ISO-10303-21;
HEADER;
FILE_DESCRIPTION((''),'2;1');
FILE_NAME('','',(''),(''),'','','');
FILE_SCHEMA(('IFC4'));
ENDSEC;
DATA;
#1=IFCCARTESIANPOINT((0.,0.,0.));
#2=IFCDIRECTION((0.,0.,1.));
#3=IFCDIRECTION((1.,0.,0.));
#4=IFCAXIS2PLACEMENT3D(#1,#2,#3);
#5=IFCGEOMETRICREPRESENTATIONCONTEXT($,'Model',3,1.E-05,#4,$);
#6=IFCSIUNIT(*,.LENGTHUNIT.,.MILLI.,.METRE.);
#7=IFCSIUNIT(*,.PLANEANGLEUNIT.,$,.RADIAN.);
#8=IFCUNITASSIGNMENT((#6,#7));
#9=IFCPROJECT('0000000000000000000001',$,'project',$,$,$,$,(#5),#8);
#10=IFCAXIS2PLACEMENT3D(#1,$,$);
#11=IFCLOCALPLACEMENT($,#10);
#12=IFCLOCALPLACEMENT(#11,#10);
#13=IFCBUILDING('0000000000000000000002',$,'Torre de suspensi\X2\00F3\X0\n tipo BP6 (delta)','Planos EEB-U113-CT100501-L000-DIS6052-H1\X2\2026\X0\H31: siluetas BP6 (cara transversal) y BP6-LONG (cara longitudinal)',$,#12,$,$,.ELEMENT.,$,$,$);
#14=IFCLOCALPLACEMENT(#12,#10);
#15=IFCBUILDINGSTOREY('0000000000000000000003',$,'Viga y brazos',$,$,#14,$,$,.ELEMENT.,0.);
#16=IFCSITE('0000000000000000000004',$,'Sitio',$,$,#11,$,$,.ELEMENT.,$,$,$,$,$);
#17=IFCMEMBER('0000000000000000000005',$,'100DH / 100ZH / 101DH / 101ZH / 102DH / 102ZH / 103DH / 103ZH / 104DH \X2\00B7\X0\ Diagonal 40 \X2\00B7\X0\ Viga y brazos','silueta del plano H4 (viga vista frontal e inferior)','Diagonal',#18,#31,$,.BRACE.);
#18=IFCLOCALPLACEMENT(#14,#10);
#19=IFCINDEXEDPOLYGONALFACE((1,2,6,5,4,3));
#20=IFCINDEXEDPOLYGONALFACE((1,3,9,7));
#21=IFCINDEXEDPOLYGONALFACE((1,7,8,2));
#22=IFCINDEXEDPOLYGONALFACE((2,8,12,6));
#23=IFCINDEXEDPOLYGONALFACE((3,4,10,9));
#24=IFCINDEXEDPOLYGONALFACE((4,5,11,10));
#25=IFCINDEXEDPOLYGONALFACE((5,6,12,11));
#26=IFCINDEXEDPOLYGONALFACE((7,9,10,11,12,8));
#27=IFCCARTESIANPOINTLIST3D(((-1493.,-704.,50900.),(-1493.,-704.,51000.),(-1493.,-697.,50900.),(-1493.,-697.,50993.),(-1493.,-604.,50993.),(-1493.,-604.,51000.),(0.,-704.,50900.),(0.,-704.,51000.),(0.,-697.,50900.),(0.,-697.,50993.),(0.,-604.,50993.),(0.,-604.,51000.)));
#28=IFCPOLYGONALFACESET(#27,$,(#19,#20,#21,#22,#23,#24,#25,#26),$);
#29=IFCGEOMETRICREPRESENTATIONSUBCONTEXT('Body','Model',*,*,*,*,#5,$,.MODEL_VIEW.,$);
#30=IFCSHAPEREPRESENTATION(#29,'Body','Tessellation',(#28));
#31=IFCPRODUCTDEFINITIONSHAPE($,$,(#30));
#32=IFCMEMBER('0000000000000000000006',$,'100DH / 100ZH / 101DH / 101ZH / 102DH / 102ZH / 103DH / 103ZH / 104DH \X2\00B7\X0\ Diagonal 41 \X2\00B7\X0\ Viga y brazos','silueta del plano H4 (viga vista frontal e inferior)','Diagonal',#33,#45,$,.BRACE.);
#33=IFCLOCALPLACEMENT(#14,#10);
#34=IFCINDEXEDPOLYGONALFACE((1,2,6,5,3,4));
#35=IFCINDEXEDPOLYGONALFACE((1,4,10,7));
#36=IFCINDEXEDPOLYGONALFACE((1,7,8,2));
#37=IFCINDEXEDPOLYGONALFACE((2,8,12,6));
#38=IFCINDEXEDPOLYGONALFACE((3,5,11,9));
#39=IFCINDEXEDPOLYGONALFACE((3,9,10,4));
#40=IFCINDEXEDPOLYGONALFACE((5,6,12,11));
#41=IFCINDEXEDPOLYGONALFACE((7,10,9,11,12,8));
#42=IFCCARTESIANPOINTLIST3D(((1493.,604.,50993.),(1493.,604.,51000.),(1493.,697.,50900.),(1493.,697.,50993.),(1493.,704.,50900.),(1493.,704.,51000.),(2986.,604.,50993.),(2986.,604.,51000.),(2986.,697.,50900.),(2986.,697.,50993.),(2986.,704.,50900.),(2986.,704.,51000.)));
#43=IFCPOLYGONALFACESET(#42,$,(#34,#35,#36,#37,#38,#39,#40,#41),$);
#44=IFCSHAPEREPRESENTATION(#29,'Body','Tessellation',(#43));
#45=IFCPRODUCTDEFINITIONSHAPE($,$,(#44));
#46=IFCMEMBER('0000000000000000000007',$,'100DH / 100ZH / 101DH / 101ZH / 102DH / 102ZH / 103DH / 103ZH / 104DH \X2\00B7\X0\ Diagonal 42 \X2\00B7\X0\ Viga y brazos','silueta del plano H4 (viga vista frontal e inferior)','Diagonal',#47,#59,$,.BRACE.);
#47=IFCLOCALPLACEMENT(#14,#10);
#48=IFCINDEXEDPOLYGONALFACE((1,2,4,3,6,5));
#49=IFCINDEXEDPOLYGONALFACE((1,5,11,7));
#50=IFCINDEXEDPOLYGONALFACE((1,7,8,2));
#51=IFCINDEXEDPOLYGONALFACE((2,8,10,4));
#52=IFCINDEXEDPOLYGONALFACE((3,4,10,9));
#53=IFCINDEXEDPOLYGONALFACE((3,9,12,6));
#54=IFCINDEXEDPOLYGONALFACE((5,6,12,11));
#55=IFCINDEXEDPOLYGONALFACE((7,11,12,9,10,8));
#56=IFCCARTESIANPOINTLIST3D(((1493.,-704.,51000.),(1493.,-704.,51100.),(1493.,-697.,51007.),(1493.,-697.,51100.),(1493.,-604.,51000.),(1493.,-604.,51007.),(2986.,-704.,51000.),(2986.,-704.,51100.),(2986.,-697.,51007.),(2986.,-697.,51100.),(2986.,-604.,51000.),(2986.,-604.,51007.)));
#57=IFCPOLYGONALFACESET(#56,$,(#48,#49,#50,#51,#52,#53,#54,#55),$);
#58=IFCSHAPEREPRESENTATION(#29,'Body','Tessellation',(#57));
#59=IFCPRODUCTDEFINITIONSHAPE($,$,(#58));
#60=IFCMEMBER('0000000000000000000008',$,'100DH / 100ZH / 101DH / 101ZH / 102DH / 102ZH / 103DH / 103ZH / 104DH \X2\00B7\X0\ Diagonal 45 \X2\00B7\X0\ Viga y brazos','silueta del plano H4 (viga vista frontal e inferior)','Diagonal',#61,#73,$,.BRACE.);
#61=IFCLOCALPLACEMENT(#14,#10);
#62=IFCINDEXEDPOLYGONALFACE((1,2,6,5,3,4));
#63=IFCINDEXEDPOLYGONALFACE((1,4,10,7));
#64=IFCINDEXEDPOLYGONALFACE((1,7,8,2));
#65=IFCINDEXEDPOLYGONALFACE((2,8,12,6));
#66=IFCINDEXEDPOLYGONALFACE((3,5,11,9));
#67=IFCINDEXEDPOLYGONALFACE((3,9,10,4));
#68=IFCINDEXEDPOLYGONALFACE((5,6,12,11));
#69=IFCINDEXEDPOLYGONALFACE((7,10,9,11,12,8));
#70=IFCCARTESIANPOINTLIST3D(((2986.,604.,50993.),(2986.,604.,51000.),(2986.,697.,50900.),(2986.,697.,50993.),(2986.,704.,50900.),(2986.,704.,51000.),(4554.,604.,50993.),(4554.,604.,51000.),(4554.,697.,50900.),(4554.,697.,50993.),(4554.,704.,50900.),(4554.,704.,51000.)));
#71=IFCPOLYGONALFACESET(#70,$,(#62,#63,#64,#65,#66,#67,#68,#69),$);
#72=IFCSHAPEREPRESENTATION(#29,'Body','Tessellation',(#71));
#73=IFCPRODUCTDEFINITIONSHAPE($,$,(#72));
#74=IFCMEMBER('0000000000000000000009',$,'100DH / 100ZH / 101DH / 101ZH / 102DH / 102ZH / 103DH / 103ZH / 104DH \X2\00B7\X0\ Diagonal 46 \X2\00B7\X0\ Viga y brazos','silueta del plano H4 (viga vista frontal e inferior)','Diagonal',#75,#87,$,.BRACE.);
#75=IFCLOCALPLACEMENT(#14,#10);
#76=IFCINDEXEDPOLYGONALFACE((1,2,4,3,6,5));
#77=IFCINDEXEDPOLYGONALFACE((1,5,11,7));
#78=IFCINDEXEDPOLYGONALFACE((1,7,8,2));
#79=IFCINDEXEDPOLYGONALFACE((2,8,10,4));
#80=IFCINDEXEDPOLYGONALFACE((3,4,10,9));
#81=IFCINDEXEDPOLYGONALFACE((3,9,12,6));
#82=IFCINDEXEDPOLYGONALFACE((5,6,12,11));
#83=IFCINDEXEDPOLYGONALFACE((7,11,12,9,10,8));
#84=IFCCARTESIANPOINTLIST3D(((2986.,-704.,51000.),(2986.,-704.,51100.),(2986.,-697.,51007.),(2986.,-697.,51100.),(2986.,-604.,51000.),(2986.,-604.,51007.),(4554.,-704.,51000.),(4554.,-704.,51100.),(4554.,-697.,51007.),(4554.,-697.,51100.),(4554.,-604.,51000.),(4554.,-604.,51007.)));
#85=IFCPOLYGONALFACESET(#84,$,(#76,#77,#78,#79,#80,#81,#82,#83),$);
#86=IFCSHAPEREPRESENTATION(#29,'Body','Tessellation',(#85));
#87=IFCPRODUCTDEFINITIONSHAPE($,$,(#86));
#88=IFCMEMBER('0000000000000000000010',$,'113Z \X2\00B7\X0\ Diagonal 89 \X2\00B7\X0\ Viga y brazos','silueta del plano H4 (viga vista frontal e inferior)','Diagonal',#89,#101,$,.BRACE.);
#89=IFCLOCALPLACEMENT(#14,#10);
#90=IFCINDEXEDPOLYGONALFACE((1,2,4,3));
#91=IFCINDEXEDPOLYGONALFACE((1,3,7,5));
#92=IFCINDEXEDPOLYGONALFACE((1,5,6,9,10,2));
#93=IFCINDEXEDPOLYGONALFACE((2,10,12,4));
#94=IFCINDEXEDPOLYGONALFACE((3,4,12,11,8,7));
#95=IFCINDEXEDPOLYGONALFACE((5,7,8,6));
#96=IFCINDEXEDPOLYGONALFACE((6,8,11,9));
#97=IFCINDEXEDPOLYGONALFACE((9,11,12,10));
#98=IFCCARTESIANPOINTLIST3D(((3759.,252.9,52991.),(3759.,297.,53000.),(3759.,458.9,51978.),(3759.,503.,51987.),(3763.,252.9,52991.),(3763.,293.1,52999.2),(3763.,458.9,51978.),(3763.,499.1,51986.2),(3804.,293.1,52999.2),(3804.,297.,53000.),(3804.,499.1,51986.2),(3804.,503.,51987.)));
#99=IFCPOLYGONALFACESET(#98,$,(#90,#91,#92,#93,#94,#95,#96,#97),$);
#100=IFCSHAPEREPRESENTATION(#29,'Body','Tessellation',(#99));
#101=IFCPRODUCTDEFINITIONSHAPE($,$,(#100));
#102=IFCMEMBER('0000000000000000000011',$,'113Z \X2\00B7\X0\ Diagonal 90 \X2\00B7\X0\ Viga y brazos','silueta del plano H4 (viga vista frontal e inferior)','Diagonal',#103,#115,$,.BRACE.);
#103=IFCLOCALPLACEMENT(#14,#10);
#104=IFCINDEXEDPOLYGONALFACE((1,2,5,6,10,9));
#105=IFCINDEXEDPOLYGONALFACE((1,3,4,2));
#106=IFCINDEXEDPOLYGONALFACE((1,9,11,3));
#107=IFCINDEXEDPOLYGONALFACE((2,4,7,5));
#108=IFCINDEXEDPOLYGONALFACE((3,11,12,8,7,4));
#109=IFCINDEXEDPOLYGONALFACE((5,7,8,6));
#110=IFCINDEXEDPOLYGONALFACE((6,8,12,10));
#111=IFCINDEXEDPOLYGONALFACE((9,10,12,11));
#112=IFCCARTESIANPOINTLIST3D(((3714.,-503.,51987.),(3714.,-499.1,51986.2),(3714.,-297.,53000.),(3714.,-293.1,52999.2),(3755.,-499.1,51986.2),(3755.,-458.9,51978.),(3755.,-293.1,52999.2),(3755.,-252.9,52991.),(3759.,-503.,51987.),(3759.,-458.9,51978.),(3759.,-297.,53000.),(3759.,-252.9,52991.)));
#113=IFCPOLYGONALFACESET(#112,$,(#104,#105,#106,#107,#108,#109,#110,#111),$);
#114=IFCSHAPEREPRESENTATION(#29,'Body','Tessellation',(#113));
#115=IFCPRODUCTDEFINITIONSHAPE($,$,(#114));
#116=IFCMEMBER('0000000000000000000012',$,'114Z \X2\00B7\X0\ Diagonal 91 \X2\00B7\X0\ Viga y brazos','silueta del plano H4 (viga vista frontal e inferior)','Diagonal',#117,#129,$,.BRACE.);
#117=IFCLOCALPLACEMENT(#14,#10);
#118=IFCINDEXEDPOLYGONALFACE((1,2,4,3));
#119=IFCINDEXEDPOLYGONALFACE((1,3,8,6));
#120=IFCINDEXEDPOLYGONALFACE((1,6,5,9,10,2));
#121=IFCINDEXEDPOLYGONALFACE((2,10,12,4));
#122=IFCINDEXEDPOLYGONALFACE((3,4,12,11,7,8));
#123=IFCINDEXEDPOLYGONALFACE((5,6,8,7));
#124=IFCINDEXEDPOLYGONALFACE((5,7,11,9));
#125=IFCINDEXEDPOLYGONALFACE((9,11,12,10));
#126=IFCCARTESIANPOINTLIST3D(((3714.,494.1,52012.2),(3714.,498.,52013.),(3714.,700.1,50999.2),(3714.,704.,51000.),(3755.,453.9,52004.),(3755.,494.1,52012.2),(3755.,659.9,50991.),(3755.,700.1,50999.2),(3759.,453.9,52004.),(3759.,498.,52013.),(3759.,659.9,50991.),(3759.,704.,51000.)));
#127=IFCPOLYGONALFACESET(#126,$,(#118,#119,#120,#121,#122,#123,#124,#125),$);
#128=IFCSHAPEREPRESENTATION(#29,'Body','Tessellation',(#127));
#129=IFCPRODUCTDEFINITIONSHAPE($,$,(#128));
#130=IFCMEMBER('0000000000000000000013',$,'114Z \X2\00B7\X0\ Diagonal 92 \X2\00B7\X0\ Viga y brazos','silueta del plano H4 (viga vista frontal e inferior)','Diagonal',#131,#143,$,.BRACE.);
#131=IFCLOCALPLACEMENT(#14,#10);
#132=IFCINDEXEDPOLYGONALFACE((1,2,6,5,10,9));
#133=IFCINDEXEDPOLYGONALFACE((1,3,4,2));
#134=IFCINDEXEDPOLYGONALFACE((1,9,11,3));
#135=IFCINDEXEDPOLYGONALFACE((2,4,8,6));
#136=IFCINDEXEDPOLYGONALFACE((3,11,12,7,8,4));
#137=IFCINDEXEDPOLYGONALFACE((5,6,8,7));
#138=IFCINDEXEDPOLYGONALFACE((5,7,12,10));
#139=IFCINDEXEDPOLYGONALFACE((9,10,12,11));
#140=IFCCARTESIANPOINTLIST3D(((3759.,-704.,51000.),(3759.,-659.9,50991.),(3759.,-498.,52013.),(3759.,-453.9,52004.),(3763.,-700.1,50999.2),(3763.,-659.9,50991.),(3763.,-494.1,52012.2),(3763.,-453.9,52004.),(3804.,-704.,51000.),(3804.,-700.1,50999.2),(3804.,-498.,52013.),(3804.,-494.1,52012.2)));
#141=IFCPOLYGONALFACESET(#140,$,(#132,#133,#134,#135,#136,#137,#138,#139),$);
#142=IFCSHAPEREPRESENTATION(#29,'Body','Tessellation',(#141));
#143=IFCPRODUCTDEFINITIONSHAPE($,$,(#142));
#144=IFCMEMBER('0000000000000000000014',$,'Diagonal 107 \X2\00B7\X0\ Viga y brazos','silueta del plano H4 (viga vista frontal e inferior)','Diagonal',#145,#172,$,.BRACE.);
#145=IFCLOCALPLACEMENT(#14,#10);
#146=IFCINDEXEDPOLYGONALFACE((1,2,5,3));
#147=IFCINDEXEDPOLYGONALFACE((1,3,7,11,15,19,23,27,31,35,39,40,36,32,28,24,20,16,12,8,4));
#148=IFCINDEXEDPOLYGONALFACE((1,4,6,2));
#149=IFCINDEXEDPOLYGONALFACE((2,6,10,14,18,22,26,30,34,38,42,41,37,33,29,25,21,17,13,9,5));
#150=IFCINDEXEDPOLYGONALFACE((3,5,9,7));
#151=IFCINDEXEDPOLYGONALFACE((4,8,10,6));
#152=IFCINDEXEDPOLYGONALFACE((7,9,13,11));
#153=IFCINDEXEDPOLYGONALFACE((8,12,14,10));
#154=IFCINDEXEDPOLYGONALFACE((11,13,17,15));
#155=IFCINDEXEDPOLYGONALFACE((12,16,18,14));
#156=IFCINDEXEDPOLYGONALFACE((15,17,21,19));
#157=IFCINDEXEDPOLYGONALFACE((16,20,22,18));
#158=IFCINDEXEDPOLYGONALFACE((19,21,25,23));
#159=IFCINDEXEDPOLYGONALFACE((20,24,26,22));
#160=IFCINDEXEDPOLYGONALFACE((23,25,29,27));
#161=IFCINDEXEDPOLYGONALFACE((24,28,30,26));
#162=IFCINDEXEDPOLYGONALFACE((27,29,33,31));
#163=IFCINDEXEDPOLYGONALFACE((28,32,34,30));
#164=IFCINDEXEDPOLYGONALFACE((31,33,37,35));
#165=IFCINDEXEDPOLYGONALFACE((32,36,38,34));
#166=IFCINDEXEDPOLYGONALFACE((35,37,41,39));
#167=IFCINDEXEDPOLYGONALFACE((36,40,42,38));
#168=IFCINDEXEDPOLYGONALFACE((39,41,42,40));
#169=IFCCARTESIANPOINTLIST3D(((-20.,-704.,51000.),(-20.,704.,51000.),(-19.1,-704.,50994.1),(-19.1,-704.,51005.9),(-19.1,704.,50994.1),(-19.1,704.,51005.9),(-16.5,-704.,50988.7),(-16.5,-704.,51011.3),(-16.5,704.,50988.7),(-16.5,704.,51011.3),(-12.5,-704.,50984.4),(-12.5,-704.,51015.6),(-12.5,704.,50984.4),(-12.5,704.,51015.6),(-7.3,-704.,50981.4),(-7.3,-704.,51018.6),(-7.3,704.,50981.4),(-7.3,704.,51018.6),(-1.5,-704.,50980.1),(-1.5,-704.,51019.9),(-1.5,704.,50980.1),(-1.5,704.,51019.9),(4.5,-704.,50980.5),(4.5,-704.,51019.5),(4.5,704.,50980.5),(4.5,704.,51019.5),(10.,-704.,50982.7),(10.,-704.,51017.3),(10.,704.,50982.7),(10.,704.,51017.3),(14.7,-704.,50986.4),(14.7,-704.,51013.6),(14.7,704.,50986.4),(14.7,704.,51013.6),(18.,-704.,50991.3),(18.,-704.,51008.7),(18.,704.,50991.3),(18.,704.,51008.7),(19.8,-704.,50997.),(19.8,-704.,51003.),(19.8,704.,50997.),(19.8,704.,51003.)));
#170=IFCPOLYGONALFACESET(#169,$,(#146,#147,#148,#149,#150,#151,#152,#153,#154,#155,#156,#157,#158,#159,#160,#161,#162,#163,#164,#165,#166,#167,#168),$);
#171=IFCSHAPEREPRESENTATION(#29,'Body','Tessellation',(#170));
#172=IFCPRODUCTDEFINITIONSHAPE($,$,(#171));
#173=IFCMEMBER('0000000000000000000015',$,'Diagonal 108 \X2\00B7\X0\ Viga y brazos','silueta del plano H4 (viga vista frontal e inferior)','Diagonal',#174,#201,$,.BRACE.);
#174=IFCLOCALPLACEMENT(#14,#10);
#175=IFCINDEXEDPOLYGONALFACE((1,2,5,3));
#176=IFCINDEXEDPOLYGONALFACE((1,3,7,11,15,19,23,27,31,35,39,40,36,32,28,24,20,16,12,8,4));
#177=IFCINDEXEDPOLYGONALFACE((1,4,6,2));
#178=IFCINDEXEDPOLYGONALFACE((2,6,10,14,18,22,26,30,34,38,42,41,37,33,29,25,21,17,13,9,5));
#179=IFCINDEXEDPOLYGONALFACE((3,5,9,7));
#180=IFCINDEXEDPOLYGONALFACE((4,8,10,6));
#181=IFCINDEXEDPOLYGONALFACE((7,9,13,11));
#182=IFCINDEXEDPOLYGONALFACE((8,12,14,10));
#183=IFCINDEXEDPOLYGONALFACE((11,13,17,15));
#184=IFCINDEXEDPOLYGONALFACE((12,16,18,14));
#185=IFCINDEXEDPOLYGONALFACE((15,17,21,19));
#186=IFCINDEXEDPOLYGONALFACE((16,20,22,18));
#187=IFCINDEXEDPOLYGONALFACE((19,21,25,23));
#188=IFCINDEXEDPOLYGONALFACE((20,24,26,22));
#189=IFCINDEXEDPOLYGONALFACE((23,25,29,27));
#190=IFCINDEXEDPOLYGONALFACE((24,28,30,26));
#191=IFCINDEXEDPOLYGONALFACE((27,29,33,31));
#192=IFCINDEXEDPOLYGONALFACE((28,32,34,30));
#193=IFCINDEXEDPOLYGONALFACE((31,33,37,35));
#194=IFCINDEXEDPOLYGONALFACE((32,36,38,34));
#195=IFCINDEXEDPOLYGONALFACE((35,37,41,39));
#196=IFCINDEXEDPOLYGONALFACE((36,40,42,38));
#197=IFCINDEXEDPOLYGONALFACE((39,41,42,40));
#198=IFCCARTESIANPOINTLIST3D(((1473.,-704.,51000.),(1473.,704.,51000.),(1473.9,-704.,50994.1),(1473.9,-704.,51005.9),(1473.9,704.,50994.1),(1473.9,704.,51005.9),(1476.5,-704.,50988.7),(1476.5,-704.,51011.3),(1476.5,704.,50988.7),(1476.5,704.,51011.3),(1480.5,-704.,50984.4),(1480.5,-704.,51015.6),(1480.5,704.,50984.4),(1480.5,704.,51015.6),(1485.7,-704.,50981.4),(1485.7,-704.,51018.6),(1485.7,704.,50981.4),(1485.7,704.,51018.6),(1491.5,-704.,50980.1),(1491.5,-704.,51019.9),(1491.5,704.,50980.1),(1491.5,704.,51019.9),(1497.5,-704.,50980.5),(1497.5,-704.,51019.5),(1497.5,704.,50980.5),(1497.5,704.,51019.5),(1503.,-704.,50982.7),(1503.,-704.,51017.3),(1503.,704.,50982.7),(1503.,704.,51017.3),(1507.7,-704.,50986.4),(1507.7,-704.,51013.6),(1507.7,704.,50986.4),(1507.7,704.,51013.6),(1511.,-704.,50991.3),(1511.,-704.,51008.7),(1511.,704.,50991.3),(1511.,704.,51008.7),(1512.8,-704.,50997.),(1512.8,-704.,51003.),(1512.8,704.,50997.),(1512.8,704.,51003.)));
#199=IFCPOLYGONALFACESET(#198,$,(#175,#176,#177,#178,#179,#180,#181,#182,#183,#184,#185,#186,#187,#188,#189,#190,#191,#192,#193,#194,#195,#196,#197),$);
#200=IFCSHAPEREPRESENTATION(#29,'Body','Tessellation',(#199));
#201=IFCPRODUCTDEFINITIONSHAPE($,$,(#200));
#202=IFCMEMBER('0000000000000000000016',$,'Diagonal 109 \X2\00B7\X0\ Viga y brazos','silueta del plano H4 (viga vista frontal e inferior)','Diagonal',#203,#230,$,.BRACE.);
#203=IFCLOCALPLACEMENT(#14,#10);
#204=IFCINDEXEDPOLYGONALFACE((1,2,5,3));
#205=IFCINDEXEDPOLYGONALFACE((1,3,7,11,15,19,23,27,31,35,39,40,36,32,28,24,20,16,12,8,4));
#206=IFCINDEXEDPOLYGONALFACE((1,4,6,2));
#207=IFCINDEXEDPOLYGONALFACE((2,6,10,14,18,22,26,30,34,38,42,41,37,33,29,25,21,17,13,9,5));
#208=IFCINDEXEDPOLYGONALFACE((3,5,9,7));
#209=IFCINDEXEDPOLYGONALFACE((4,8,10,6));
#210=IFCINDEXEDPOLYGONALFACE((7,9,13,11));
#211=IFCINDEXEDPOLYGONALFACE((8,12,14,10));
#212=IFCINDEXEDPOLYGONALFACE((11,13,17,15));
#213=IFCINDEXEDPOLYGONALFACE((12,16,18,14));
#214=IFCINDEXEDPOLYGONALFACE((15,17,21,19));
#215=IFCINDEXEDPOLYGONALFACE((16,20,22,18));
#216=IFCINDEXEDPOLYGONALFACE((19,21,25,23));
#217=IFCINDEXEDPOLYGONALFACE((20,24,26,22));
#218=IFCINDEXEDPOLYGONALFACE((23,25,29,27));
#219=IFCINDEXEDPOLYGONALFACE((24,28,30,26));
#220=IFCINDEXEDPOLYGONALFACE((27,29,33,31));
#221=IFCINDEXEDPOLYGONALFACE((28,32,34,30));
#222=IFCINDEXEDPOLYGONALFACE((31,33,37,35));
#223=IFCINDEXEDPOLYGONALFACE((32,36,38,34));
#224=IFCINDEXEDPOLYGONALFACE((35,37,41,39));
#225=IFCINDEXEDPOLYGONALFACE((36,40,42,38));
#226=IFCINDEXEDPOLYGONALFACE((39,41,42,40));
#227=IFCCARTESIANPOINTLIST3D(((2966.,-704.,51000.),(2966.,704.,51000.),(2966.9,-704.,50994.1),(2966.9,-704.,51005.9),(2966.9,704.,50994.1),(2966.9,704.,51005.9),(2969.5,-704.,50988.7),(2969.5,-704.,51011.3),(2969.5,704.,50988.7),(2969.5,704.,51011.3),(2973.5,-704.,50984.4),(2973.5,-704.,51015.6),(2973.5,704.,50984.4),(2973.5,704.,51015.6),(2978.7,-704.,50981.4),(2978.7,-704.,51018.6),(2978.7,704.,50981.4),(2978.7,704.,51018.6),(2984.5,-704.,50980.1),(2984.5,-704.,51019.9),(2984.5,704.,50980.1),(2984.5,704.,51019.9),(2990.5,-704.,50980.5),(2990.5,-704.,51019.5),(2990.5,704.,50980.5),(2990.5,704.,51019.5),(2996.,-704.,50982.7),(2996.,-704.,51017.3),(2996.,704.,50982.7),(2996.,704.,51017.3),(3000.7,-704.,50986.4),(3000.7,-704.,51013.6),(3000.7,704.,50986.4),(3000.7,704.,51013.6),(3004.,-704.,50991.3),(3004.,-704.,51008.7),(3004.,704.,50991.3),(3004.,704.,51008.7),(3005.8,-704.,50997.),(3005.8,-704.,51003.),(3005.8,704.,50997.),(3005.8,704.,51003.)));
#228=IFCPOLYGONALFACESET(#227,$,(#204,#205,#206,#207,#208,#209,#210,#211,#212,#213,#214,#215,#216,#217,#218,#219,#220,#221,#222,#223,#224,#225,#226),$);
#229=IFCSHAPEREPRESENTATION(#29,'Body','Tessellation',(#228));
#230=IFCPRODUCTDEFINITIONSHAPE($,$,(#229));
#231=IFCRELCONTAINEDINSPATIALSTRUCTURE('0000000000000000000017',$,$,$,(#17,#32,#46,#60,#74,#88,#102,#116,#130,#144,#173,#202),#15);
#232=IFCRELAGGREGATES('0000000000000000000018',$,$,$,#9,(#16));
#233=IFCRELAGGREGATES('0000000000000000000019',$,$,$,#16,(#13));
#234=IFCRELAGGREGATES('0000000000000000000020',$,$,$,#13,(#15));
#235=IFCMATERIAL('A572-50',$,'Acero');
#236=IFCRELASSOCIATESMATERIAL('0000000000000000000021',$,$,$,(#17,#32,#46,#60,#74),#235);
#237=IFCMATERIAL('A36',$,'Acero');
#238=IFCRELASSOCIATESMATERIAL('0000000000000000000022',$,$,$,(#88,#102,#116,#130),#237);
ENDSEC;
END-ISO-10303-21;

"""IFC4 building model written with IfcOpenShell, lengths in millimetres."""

from ifc_helpers import new_model, si_unit, frame, frame_2d, origin, origin_with_axes, place, context, subcontext, project, spatial, circle, l_section, extrude, material, element, save


model = new_model("IFC4")

# Units and contexts
model_context = context("Model", 3, precision=1e-05, world=origin_with_axes())
body_context = subcontext(model_context, "Body", "Model", "MODEL_VIEW")
ifc_project = project(units=[si_unit("LENGTHUNIT", "METRE", prefix="MILLI"), si_unit("PLANEANGLEUNIT", "RADIAN")], contexts=[model_context])

# Site, building, storey
site_placement = place(None, origin())
site = spatial("IfcSite", under=ifc_project, at=site_placement, Name="Sitio", CompositionType="ELEMENT")
building_placement = place(site_placement, origin())
building = spatial("IfcBuilding", under=site, at=building_placement, Name="Torre de suspensión tipo BP6 (delta)", Description="Planos EEB-U113-CT100501-L000-DIS6052-H1…H31: siluetas BP6 (cara transversal) y BP6-LONG (cara longitudinal)", CompositionType="ELEMENT")
storey_placement = place(building_placement, origin())
storey = spatial("IfcBuildingStorey", under=building, at=storey_placement, Name="Viga y brazos", CompositionType="ELEMENT", Elevation=0.0)

# Members
ifc_material_1 = material(Name="A572-50", Category="Acero")
ifc_material_2 = material(Name="A36", Category="Acero")
for number, where, z_axis, x_axis, name in (
    (1, (0.0, -704.0, 51000.0), (-1.0, 0.0, 0.0), (0.0, 1.0, 0.0), "100DH / 100ZH / 101DH / 101ZH / 102DH / 102ZH / 103DH / 103ZH / 104DH · Diagonal 40 · Viga y brazos"),
    (2, (1493.0, 704.0, 51000.0), (1.0, 0.0, 0.0), (0.0, -1.0, 0.0), "100DH / 100ZH / 101DH / 101ZH / 102DH / 102ZH / 103DH / 103ZH / 104DH · Diagonal 41 · Viga y brazos"),
    (3, (1493.0, -704.0, 51000.0), (1.0, 0.0, 0.0), (0.0, 1.0, 0.0), "100DH / 100ZH / 101DH / 101ZH / 102DH / 102ZH / 103DH / 103ZH / 104DH · Diagonal 42 · Viga y brazos"),
):
    element("IfcMember", number, at=place(storey_placement, frame(where, z_axis=z_axis, x_axis=x_axis)), inside=storey, material=ifc_material_1, Name=name, Description="silueta del plano H4 (viga vista frontal e inferior)", ObjectType="Diagonal", PredefinedType="BRACE", context=body_context, shape_type="SweptSolid", body=[
        extrude(l_section(Depth=100.0, Width=100.0, Thickness=7.0, at=frame_2d((50.0, 50.0))), None, (0.0, 0.0, 1.0), 1493.0),
    ])
for number, where, z_axis, x_axis, name in (
    (4, (2986.0, 704.0, 51000.0), (1.0, 0.0, 0.0), (0.0, -1.0, 0.0), "100DH / 100ZH / 101DH / 101ZH / 102DH / 102ZH / 103DH / 103ZH / 104DH · Diagonal 45 · Viga y brazos"),
    (5, (2986.0, -704.0, 51000.0), (1.0, 0.0, 0.0), (0.0, 1.0, 0.0), "100DH / 100ZH / 101DH / 101ZH / 102DH / 102ZH / 103DH / 103ZH / 104DH · Diagonal 46 · Viga y brazos"),
):
    element("IfcMember", number, at=place(storey_placement, frame(where, z_axis=z_axis, x_axis=x_axis)), inside=storey, material=ifc_material_1, Name=name, Description="silueta del plano H4 (viga vista frontal e inferior)", ObjectType="Diagonal", PredefinedType="BRACE", context=body_context, shape_type="SweptSolid", body=[
        extrude(l_section(Depth=100.0, Width=100.0, Thickness=7.0, at=frame_2d((50.0, 50.0))), None, (0.0, 0.0, 1.0), 1568.0),
    ])
for number, where, z_axis, x_axis, name in (
    (6, (3759.0, 503.0, 51987.0), (0.0, -0.199278, 0.979943), (0.0, -0.979943, -0.199278), "113Z · Diagonal 89 · Viga y brazos"),
    (7, (3759.0, -503.0, 51987.0), (0.0, 0.199278, 0.979943), (0.0, 0.979943, -0.199278), "113Z · Diagonal 90 · Viga y brazos"),
    (8, (3759.0, 498.0, 52013.0), (0.0, 0.199278, -0.979943), (0.0, -0.979943, -0.199278), "114Z · Diagonal 91 · Viga y brazos"),
    (9, (3759.0, -498.0, 52013.0), (0.0, -0.199278, -0.979943), (0.0, 0.979943, -0.199278), "114Z · Diagonal 92 · Viga y brazos"),
):
    element("IfcMember", number, at=place(storey_placement, frame(where, z_axis=z_axis, x_axis=x_axis)), inside=storey, material=ifc_material_2, Name=name, Description="silueta del plano H4 (viga vista frontal e inferior)", ObjectType="Diagonal", PredefinedType="BRACE", context=body_context, shape_type="SweptSolid", body=[
        extrude(l_section(Depth=45.0, Width=45.0, Thickness=4.0, at=frame_2d((22.5, 22.5))), None, (0.0, 0.0, 1.0), 1033.7),
    ])
for number, where, z_axis, x_axis, name in (
    (10, (0.0, 704.0, 51000.0), (0.0, -1.0, 0.0), (-1.0, 0.0, 0.0), "Diagonal 107 · Viga y brazos"),
    (11, (1493.0, 704.0, 51000.0), (0.0, -1.0, 0.0), (-1.0, 0.0, 0.0), "Diagonal 108 · Viga y brazos"),
    (12, (2986.0, 704.0, 51000.0), (0.0, -1.0, 0.0), (-1.0, 0.0, 0.0), "Diagonal 109 · Viga y brazos"),
):
    element("IfcMember", number, at=place(storey_placement, frame(where, z_axis=z_axis, x_axis=x_axis)), inside=storey, Name=name, Description="silueta del plano H4 (viga vista frontal e inferior)", ObjectType="Diagonal", PredefinedType="BRACE", context=body_context, shape_type="SweptSolid", body=[
        extrude(circle(Radius=20.0), None, (0.0, 0.0, 1.0), 1408.0),
    ])

save(model, "model.ifc")
